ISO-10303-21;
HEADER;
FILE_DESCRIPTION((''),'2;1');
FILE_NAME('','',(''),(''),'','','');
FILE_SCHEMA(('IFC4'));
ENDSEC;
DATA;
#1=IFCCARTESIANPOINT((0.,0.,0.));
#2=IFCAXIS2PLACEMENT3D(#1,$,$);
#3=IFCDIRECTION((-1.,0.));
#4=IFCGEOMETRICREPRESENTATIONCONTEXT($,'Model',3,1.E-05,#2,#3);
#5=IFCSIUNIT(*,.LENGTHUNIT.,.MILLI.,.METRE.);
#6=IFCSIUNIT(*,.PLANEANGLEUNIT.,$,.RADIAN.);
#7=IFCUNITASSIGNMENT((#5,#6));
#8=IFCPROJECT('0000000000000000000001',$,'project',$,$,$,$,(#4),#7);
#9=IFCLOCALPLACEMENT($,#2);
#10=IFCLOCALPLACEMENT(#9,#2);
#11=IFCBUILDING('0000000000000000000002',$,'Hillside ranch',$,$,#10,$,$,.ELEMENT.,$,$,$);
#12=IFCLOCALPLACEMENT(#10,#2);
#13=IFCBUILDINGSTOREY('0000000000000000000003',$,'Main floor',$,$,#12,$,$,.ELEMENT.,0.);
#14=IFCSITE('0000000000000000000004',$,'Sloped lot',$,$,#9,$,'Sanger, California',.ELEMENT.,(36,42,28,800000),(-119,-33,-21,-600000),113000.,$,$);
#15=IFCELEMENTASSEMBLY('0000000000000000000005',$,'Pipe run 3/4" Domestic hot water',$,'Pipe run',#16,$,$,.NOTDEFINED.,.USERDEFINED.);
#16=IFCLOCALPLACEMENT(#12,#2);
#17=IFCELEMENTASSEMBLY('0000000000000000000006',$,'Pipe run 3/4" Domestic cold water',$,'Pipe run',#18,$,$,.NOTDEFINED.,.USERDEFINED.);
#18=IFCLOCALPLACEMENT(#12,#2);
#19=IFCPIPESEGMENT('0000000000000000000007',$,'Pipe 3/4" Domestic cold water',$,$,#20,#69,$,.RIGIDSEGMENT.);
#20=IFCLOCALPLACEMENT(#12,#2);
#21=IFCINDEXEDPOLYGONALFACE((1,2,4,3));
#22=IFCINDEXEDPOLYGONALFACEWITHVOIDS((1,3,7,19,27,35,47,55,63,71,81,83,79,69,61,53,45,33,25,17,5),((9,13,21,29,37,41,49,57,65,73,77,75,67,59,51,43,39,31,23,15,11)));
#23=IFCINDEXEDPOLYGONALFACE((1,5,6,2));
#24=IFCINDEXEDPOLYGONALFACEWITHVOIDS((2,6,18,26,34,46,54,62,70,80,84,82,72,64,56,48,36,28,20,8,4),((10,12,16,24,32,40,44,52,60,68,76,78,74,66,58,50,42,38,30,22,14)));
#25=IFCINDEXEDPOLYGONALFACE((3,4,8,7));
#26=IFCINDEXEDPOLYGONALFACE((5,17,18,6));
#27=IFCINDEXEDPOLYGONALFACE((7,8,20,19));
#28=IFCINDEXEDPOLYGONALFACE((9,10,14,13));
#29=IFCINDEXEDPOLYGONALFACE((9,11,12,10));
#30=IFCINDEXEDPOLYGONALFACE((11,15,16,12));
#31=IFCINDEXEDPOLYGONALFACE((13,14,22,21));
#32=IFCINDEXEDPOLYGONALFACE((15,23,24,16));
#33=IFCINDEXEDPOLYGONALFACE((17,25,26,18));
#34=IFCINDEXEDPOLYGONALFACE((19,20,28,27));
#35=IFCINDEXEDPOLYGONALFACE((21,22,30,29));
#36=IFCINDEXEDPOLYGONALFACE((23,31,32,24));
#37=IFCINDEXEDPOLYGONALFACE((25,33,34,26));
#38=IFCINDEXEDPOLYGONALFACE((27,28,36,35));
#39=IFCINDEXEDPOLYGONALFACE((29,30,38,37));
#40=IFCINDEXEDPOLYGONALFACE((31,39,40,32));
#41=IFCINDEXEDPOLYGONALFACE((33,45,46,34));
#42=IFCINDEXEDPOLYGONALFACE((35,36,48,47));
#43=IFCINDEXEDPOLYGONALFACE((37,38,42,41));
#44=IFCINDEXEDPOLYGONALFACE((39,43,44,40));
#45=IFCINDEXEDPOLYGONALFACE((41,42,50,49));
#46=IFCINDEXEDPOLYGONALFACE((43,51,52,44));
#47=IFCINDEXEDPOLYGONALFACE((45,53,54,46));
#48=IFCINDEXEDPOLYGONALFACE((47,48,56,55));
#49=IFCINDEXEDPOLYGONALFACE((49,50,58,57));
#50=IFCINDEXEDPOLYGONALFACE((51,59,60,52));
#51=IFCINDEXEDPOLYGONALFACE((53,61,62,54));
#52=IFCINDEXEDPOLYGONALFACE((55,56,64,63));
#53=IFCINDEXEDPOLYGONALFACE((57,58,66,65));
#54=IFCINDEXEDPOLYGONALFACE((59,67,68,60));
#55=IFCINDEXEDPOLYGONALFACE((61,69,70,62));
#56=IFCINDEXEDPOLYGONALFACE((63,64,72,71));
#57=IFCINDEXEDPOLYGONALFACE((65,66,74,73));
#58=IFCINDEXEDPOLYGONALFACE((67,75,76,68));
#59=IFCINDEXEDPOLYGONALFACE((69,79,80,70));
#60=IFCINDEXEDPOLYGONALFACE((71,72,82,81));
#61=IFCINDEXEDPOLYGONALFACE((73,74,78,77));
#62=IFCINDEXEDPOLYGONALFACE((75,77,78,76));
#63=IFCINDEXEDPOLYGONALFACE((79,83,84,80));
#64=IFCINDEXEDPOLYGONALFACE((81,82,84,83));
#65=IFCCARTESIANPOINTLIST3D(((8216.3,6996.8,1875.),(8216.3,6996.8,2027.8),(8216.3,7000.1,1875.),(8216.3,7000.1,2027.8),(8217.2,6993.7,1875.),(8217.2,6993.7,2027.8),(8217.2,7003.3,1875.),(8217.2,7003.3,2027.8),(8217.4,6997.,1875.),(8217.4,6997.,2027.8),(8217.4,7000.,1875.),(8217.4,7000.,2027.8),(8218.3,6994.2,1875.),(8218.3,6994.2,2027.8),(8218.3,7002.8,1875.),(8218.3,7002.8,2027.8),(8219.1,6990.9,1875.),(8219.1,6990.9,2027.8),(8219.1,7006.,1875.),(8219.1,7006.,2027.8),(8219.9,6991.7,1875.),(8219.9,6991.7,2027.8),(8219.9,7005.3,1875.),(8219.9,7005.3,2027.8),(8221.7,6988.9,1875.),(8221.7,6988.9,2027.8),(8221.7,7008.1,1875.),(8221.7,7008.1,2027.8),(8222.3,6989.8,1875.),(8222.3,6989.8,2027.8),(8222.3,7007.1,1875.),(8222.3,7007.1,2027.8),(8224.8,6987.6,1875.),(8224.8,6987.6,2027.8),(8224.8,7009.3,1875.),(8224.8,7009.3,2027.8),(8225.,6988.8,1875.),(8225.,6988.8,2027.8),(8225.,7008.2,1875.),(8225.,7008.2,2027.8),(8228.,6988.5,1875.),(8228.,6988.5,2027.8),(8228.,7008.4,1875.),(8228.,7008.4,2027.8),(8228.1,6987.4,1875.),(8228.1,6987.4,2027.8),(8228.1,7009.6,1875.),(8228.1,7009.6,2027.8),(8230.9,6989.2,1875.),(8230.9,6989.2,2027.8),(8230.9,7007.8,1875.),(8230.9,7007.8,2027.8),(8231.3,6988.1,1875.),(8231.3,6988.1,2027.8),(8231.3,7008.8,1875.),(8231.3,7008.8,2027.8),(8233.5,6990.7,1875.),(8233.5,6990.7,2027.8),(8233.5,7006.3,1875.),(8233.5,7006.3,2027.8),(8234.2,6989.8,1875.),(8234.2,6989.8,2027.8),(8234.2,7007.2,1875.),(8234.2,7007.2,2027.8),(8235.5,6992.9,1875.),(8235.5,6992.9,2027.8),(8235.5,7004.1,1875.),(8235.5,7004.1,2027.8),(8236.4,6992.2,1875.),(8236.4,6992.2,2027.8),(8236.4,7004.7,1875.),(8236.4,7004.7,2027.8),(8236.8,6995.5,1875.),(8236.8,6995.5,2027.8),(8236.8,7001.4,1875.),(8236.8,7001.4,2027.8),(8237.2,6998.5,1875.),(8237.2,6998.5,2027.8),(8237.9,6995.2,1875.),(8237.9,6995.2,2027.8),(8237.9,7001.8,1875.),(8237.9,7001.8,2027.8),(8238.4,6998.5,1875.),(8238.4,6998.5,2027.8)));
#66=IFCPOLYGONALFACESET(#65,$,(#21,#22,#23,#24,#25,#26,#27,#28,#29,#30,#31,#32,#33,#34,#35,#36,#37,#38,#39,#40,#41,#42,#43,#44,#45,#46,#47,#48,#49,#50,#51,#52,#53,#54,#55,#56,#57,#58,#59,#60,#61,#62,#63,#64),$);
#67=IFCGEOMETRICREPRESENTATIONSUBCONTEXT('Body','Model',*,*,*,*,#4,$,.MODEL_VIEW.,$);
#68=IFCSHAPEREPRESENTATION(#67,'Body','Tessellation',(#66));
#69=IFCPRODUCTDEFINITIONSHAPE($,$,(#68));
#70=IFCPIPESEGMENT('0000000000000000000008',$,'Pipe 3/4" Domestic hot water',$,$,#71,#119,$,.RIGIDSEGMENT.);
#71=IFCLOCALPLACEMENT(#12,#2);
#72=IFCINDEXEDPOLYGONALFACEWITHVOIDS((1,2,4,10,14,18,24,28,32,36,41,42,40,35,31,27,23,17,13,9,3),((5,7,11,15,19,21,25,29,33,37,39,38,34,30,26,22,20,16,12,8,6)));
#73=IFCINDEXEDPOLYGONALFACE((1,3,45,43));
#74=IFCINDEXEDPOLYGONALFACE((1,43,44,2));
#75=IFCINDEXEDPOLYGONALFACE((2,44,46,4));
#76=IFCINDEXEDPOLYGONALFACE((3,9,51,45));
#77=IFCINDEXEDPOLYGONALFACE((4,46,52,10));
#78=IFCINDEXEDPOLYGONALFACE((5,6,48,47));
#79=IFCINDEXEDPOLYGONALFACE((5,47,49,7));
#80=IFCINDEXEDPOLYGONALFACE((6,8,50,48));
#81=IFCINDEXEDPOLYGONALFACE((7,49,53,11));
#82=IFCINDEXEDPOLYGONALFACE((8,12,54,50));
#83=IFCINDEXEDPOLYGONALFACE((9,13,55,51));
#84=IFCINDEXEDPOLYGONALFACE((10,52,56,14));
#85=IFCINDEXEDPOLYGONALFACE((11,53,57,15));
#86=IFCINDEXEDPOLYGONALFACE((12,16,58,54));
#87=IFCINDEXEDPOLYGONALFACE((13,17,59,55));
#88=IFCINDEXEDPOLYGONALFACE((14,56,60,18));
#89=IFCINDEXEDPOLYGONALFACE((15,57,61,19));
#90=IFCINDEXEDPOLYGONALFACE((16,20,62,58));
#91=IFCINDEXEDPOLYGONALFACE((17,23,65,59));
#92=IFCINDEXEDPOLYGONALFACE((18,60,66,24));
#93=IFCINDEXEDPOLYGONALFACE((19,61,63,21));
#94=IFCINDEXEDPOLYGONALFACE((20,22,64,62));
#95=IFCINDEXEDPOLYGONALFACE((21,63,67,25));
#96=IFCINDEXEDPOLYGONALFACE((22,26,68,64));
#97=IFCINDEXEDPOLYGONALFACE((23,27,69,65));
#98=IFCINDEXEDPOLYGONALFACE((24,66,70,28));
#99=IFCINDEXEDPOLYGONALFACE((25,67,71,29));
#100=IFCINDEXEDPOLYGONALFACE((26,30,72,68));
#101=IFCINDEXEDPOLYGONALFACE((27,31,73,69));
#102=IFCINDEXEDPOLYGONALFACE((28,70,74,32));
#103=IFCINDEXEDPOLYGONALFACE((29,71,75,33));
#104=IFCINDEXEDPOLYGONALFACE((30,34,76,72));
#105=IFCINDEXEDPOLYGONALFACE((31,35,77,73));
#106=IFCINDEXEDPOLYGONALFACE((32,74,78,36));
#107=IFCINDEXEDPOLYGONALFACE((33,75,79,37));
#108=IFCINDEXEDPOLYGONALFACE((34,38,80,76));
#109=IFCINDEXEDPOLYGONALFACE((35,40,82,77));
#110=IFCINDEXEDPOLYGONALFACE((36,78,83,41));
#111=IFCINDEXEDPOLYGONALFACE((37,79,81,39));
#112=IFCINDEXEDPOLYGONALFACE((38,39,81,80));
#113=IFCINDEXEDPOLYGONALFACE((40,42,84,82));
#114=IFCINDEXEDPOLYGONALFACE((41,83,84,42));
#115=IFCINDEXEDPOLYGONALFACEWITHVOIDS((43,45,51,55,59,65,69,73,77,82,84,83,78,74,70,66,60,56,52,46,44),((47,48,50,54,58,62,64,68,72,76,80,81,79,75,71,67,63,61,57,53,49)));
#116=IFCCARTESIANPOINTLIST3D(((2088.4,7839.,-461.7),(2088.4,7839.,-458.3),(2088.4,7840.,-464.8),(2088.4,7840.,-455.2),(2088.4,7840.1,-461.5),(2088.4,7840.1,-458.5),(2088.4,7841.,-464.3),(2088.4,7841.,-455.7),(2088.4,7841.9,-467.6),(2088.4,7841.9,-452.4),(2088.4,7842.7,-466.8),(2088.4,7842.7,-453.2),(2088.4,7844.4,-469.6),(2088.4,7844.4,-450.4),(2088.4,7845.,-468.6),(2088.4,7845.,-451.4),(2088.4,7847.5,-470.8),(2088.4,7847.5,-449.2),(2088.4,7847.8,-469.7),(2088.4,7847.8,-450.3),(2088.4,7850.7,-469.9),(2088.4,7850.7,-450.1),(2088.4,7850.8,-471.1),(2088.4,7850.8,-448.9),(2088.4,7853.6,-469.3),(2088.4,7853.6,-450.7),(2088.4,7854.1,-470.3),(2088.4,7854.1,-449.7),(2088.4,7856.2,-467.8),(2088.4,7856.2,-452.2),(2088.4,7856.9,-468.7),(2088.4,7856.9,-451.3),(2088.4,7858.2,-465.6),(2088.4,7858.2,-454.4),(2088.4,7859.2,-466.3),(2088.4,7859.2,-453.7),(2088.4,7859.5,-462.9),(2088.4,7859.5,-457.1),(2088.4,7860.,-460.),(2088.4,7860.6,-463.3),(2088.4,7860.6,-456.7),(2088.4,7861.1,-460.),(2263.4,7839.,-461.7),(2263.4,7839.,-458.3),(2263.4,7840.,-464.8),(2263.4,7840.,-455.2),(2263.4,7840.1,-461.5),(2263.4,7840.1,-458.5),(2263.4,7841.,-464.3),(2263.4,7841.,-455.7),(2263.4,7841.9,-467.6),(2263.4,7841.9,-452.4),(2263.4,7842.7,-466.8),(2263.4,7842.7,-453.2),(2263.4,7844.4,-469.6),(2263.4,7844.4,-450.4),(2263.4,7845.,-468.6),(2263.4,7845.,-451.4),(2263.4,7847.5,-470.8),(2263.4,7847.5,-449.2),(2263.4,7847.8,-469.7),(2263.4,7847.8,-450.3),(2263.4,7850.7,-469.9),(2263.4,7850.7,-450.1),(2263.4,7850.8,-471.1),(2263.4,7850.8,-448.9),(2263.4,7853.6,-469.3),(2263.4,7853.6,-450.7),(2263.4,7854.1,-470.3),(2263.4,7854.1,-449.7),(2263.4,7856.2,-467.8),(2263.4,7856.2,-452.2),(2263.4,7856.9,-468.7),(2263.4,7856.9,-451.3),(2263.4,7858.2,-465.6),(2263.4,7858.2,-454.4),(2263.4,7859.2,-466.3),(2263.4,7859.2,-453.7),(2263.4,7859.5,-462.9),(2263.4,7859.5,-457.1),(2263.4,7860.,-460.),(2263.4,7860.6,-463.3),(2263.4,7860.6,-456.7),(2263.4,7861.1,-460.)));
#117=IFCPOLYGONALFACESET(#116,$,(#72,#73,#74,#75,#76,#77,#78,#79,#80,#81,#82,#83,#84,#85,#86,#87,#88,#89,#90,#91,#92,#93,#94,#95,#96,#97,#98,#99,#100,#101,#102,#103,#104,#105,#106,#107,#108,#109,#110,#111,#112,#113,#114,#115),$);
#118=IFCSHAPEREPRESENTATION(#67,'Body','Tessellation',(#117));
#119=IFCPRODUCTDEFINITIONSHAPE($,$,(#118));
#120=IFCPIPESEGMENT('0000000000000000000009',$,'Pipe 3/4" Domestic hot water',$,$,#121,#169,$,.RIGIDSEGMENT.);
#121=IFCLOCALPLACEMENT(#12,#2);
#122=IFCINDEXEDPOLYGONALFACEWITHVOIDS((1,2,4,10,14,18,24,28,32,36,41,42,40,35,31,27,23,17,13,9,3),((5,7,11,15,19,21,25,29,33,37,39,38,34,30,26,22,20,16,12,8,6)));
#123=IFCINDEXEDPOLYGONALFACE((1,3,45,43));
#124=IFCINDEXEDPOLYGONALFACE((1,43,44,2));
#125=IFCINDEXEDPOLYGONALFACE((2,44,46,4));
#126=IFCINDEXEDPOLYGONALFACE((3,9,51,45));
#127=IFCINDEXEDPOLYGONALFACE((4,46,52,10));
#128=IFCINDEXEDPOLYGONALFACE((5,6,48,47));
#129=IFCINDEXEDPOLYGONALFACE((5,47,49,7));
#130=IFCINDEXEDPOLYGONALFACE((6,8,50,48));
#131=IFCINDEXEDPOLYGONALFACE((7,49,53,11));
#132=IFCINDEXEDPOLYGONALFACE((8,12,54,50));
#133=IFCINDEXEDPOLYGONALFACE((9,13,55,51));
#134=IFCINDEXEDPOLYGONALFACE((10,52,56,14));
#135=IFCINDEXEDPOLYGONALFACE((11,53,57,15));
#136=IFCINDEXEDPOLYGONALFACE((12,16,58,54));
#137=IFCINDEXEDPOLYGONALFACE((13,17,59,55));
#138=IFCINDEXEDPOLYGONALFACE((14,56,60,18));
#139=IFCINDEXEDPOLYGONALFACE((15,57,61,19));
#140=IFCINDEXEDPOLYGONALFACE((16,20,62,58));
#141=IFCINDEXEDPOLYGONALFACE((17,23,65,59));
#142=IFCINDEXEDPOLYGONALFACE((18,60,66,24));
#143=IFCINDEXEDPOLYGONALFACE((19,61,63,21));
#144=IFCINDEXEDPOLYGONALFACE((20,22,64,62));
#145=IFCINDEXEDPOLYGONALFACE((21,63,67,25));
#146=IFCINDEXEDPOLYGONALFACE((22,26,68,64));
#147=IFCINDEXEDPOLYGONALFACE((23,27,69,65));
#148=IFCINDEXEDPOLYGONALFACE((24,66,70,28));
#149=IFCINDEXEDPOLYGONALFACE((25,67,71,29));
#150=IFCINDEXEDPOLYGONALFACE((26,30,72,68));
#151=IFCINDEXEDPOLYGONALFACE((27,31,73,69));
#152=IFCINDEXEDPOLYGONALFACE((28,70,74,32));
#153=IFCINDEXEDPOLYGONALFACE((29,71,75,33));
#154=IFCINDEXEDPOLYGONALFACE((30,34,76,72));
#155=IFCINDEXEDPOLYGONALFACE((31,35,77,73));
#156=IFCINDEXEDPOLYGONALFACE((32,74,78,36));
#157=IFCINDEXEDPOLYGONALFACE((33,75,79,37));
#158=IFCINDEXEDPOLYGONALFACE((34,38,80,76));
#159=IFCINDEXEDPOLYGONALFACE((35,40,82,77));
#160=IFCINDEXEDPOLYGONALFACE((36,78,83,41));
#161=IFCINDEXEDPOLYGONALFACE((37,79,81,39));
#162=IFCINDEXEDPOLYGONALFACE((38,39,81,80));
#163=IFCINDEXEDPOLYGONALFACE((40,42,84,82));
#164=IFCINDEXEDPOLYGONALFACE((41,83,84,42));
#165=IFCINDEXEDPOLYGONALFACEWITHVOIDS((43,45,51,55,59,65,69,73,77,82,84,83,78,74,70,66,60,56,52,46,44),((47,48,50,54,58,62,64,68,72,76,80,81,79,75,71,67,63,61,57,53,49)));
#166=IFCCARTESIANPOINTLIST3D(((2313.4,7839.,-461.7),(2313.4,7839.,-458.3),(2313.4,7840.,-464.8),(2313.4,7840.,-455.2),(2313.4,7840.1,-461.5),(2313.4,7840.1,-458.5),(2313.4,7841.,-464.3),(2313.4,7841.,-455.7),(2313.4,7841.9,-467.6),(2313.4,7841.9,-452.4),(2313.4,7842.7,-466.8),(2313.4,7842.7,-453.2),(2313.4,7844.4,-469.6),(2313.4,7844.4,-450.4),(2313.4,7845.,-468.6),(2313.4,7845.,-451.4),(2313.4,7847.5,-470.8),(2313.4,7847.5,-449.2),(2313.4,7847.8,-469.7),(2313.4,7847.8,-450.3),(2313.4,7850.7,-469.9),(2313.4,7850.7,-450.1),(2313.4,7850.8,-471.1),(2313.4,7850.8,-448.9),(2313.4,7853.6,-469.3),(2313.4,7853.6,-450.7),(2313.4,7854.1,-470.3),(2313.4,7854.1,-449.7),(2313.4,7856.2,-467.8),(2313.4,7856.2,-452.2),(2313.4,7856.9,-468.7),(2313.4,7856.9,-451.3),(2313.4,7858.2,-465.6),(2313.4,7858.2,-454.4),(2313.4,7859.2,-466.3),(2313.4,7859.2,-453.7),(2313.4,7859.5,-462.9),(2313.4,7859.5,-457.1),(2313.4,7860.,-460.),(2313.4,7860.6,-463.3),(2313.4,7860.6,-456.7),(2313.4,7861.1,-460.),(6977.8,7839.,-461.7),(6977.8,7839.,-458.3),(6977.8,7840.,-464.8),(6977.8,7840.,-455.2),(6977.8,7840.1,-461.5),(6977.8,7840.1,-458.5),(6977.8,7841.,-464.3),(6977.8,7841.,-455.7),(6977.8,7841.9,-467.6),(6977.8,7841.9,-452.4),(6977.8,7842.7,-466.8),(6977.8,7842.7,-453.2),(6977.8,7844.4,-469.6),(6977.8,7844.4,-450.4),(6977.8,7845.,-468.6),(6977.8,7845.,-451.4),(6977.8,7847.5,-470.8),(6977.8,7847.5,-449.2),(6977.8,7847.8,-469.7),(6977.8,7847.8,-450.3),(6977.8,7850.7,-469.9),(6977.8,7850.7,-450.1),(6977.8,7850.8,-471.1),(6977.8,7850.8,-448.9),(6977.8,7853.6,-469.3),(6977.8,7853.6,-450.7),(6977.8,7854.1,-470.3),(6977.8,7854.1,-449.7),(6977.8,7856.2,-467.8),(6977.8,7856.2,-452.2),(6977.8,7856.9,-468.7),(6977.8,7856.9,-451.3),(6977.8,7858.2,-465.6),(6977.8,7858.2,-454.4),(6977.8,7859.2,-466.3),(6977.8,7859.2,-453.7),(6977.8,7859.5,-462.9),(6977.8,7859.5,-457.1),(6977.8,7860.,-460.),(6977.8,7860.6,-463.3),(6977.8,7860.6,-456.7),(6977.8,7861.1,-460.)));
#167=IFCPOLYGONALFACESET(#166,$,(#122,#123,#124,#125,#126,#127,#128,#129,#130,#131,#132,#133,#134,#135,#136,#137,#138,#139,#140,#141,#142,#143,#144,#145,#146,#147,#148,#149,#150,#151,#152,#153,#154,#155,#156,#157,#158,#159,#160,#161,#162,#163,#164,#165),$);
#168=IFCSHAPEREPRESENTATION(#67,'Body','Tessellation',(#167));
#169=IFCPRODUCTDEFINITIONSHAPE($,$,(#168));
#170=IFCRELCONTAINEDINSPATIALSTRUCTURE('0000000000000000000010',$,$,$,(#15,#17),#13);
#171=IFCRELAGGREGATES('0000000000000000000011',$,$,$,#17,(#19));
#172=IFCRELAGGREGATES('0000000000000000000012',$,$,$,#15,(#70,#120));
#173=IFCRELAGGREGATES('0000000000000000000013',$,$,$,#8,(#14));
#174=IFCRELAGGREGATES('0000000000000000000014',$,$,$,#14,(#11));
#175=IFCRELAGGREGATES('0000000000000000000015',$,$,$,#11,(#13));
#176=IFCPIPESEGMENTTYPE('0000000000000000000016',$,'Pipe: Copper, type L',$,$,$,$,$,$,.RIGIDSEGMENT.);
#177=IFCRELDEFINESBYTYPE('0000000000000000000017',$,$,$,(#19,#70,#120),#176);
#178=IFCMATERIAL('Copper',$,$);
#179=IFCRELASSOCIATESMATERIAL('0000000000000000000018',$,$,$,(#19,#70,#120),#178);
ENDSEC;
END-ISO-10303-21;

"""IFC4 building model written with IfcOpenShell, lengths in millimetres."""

from ifc_helpers import new_model, si_unit, direction, frame, origin, origin_with_axes, origin_2d, place, context, subcontext, project, spatial, hollow_circle, extrude, material, type_object, element, aggregate, save


model = new_model("IFC4")

# Units and contexts
model_context = context("Model", 3, precision=1e-05, world=origin(), true_north=direction((-1.0, 0.0)))
body_context = subcontext(model_context, "Body", "Model", "MODEL_VIEW")
ifc_project = project(units=[si_unit("LENGTHUNIT", "METRE", prefix="MILLI"), si_unit("PLANEANGLEUNIT", "RADIAN")], contexts=[model_context])

# Site, building, storey
site_placement = place(None, origin())
site = spatial("IfcSite", under=ifc_project, at=site_placement, Name="Sloped lot", LongName="Sanger, California", CompositionType="ELEMENT", RefLatitude=(36, 42, 28, 800000), RefLongitude=(-119, -33, -21, -600000), RefElevation=113000.0)
building_placement = place(site_placement, origin())
building = spatial("IfcBuilding", under=site, at=building_placement, Name="Hillside ranch", CompositionType="ELEMENT")
storey_placement = place(building_placement, origin())
storey = spatial("IfcBuildingStorey", under=building, at=storey_placement, Name="Main floor", CompositionType="ELEMENT", Elevation=0.0)

# Element assemblies
ifc_material = material(Name="Copper")
assembly_1_placement = place(storey_placement, origin_with_axes())
assembly_1 = element("IfcElementAssembly", 1, at=assembly_1_placement, inside=storey, Name="Pipe run 3/4\" Domestic hot water", ObjectType="Pipe run", AssemblyPlace="NOTDEFINED", PredefinedType="USERDEFINED")
assembly_2_placement = place(storey_placement, origin_with_axes())
assembly_2 = element("IfcElementAssembly", 2, at=assembly_2_placement, inside=storey, Name="Pipe run 3/4\" Domestic cold water", ObjectType="Pipe run", AssemblyPlace="NOTDEFINED", PredefinedType="USERDEFINED")

# Pipe segments
pipe_segment_type = type_object("IfcPipeSegmentType", Name="Pipe: Copper, type L", PredefinedType="RIGIDSEGMENT")
pipe_segment_1_placement = place(storey_placement, origin_with_axes())
pipe_segment_1 = element("IfcPipeSegment", 3, at=pipe_segment_1_placement, type_object=pipe_segment_type, material=ifc_material, Name="Pipe 3/4\" Domestic cold water", PredefinedType="RIGIDSEGMENT", context=body_context, shape_type="SweptSolid", body=[
    extrude(hollow_circle(Radius=11.1, WallThickness=1.1, at=origin_2d()), frame((8227.2, 6998.5, 2027.8), z_axis=(0.0, 0.0, -1.0), x_axis=(1.0, 0.0, 0.0)), (0.0, 0.0, 1.0), 152.8),
])
aggregate(assembly_2, [pipe_segment_1])
pipe_segment_2_placement = place(storey_placement, origin_with_axes())
pipe_segment_2 = element("IfcPipeSegment", 4, at=pipe_segment_2_placement, type_object=pipe_segment_type, material=ifc_material, Name="Pipe 3/4\" Domestic hot water", PredefinedType="RIGIDSEGMENT", context=body_context, shape_type="SweptSolid", body=[
    extrude(hollow_circle(Radius=11.1, WallThickness=1.1, at=origin_2d()), frame((2088.4, 7850.0, -460.0), z_axis=(1.0, 0.0, 0.0), x_axis=(0.0, 1.0, 0.0)), (0.0, 0.0, 1.0), 175.0),
])
pipe_segment_3_placement = place(storey_placement, origin_with_axes())
pipe_segment_3 = element("IfcPipeSegment", 5, at=pipe_segment_3_placement, type_object=pipe_segment_type, material=ifc_material, Name="Pipe 3/4\" Domestic hot water", PredefinedType="RIGIDSEGMENT", context=body_context, shape_type="SweptSolid", body=[
    extrude(hollow_circle(Radius=11.1, WallThickness=1.1, at=origin_2d()), frame((2313.4, 7850.0, -460.0), z_axis=(1.0, 0.0, 0.0), x_axis=(0.0, 1.0, 0.0)), (0.0, 0.0, 1.0), 4664.4),
])
aggregate(assembly_1, [pipe_segment_2, pipe_segment_3])

save(model, "model.ifc")
